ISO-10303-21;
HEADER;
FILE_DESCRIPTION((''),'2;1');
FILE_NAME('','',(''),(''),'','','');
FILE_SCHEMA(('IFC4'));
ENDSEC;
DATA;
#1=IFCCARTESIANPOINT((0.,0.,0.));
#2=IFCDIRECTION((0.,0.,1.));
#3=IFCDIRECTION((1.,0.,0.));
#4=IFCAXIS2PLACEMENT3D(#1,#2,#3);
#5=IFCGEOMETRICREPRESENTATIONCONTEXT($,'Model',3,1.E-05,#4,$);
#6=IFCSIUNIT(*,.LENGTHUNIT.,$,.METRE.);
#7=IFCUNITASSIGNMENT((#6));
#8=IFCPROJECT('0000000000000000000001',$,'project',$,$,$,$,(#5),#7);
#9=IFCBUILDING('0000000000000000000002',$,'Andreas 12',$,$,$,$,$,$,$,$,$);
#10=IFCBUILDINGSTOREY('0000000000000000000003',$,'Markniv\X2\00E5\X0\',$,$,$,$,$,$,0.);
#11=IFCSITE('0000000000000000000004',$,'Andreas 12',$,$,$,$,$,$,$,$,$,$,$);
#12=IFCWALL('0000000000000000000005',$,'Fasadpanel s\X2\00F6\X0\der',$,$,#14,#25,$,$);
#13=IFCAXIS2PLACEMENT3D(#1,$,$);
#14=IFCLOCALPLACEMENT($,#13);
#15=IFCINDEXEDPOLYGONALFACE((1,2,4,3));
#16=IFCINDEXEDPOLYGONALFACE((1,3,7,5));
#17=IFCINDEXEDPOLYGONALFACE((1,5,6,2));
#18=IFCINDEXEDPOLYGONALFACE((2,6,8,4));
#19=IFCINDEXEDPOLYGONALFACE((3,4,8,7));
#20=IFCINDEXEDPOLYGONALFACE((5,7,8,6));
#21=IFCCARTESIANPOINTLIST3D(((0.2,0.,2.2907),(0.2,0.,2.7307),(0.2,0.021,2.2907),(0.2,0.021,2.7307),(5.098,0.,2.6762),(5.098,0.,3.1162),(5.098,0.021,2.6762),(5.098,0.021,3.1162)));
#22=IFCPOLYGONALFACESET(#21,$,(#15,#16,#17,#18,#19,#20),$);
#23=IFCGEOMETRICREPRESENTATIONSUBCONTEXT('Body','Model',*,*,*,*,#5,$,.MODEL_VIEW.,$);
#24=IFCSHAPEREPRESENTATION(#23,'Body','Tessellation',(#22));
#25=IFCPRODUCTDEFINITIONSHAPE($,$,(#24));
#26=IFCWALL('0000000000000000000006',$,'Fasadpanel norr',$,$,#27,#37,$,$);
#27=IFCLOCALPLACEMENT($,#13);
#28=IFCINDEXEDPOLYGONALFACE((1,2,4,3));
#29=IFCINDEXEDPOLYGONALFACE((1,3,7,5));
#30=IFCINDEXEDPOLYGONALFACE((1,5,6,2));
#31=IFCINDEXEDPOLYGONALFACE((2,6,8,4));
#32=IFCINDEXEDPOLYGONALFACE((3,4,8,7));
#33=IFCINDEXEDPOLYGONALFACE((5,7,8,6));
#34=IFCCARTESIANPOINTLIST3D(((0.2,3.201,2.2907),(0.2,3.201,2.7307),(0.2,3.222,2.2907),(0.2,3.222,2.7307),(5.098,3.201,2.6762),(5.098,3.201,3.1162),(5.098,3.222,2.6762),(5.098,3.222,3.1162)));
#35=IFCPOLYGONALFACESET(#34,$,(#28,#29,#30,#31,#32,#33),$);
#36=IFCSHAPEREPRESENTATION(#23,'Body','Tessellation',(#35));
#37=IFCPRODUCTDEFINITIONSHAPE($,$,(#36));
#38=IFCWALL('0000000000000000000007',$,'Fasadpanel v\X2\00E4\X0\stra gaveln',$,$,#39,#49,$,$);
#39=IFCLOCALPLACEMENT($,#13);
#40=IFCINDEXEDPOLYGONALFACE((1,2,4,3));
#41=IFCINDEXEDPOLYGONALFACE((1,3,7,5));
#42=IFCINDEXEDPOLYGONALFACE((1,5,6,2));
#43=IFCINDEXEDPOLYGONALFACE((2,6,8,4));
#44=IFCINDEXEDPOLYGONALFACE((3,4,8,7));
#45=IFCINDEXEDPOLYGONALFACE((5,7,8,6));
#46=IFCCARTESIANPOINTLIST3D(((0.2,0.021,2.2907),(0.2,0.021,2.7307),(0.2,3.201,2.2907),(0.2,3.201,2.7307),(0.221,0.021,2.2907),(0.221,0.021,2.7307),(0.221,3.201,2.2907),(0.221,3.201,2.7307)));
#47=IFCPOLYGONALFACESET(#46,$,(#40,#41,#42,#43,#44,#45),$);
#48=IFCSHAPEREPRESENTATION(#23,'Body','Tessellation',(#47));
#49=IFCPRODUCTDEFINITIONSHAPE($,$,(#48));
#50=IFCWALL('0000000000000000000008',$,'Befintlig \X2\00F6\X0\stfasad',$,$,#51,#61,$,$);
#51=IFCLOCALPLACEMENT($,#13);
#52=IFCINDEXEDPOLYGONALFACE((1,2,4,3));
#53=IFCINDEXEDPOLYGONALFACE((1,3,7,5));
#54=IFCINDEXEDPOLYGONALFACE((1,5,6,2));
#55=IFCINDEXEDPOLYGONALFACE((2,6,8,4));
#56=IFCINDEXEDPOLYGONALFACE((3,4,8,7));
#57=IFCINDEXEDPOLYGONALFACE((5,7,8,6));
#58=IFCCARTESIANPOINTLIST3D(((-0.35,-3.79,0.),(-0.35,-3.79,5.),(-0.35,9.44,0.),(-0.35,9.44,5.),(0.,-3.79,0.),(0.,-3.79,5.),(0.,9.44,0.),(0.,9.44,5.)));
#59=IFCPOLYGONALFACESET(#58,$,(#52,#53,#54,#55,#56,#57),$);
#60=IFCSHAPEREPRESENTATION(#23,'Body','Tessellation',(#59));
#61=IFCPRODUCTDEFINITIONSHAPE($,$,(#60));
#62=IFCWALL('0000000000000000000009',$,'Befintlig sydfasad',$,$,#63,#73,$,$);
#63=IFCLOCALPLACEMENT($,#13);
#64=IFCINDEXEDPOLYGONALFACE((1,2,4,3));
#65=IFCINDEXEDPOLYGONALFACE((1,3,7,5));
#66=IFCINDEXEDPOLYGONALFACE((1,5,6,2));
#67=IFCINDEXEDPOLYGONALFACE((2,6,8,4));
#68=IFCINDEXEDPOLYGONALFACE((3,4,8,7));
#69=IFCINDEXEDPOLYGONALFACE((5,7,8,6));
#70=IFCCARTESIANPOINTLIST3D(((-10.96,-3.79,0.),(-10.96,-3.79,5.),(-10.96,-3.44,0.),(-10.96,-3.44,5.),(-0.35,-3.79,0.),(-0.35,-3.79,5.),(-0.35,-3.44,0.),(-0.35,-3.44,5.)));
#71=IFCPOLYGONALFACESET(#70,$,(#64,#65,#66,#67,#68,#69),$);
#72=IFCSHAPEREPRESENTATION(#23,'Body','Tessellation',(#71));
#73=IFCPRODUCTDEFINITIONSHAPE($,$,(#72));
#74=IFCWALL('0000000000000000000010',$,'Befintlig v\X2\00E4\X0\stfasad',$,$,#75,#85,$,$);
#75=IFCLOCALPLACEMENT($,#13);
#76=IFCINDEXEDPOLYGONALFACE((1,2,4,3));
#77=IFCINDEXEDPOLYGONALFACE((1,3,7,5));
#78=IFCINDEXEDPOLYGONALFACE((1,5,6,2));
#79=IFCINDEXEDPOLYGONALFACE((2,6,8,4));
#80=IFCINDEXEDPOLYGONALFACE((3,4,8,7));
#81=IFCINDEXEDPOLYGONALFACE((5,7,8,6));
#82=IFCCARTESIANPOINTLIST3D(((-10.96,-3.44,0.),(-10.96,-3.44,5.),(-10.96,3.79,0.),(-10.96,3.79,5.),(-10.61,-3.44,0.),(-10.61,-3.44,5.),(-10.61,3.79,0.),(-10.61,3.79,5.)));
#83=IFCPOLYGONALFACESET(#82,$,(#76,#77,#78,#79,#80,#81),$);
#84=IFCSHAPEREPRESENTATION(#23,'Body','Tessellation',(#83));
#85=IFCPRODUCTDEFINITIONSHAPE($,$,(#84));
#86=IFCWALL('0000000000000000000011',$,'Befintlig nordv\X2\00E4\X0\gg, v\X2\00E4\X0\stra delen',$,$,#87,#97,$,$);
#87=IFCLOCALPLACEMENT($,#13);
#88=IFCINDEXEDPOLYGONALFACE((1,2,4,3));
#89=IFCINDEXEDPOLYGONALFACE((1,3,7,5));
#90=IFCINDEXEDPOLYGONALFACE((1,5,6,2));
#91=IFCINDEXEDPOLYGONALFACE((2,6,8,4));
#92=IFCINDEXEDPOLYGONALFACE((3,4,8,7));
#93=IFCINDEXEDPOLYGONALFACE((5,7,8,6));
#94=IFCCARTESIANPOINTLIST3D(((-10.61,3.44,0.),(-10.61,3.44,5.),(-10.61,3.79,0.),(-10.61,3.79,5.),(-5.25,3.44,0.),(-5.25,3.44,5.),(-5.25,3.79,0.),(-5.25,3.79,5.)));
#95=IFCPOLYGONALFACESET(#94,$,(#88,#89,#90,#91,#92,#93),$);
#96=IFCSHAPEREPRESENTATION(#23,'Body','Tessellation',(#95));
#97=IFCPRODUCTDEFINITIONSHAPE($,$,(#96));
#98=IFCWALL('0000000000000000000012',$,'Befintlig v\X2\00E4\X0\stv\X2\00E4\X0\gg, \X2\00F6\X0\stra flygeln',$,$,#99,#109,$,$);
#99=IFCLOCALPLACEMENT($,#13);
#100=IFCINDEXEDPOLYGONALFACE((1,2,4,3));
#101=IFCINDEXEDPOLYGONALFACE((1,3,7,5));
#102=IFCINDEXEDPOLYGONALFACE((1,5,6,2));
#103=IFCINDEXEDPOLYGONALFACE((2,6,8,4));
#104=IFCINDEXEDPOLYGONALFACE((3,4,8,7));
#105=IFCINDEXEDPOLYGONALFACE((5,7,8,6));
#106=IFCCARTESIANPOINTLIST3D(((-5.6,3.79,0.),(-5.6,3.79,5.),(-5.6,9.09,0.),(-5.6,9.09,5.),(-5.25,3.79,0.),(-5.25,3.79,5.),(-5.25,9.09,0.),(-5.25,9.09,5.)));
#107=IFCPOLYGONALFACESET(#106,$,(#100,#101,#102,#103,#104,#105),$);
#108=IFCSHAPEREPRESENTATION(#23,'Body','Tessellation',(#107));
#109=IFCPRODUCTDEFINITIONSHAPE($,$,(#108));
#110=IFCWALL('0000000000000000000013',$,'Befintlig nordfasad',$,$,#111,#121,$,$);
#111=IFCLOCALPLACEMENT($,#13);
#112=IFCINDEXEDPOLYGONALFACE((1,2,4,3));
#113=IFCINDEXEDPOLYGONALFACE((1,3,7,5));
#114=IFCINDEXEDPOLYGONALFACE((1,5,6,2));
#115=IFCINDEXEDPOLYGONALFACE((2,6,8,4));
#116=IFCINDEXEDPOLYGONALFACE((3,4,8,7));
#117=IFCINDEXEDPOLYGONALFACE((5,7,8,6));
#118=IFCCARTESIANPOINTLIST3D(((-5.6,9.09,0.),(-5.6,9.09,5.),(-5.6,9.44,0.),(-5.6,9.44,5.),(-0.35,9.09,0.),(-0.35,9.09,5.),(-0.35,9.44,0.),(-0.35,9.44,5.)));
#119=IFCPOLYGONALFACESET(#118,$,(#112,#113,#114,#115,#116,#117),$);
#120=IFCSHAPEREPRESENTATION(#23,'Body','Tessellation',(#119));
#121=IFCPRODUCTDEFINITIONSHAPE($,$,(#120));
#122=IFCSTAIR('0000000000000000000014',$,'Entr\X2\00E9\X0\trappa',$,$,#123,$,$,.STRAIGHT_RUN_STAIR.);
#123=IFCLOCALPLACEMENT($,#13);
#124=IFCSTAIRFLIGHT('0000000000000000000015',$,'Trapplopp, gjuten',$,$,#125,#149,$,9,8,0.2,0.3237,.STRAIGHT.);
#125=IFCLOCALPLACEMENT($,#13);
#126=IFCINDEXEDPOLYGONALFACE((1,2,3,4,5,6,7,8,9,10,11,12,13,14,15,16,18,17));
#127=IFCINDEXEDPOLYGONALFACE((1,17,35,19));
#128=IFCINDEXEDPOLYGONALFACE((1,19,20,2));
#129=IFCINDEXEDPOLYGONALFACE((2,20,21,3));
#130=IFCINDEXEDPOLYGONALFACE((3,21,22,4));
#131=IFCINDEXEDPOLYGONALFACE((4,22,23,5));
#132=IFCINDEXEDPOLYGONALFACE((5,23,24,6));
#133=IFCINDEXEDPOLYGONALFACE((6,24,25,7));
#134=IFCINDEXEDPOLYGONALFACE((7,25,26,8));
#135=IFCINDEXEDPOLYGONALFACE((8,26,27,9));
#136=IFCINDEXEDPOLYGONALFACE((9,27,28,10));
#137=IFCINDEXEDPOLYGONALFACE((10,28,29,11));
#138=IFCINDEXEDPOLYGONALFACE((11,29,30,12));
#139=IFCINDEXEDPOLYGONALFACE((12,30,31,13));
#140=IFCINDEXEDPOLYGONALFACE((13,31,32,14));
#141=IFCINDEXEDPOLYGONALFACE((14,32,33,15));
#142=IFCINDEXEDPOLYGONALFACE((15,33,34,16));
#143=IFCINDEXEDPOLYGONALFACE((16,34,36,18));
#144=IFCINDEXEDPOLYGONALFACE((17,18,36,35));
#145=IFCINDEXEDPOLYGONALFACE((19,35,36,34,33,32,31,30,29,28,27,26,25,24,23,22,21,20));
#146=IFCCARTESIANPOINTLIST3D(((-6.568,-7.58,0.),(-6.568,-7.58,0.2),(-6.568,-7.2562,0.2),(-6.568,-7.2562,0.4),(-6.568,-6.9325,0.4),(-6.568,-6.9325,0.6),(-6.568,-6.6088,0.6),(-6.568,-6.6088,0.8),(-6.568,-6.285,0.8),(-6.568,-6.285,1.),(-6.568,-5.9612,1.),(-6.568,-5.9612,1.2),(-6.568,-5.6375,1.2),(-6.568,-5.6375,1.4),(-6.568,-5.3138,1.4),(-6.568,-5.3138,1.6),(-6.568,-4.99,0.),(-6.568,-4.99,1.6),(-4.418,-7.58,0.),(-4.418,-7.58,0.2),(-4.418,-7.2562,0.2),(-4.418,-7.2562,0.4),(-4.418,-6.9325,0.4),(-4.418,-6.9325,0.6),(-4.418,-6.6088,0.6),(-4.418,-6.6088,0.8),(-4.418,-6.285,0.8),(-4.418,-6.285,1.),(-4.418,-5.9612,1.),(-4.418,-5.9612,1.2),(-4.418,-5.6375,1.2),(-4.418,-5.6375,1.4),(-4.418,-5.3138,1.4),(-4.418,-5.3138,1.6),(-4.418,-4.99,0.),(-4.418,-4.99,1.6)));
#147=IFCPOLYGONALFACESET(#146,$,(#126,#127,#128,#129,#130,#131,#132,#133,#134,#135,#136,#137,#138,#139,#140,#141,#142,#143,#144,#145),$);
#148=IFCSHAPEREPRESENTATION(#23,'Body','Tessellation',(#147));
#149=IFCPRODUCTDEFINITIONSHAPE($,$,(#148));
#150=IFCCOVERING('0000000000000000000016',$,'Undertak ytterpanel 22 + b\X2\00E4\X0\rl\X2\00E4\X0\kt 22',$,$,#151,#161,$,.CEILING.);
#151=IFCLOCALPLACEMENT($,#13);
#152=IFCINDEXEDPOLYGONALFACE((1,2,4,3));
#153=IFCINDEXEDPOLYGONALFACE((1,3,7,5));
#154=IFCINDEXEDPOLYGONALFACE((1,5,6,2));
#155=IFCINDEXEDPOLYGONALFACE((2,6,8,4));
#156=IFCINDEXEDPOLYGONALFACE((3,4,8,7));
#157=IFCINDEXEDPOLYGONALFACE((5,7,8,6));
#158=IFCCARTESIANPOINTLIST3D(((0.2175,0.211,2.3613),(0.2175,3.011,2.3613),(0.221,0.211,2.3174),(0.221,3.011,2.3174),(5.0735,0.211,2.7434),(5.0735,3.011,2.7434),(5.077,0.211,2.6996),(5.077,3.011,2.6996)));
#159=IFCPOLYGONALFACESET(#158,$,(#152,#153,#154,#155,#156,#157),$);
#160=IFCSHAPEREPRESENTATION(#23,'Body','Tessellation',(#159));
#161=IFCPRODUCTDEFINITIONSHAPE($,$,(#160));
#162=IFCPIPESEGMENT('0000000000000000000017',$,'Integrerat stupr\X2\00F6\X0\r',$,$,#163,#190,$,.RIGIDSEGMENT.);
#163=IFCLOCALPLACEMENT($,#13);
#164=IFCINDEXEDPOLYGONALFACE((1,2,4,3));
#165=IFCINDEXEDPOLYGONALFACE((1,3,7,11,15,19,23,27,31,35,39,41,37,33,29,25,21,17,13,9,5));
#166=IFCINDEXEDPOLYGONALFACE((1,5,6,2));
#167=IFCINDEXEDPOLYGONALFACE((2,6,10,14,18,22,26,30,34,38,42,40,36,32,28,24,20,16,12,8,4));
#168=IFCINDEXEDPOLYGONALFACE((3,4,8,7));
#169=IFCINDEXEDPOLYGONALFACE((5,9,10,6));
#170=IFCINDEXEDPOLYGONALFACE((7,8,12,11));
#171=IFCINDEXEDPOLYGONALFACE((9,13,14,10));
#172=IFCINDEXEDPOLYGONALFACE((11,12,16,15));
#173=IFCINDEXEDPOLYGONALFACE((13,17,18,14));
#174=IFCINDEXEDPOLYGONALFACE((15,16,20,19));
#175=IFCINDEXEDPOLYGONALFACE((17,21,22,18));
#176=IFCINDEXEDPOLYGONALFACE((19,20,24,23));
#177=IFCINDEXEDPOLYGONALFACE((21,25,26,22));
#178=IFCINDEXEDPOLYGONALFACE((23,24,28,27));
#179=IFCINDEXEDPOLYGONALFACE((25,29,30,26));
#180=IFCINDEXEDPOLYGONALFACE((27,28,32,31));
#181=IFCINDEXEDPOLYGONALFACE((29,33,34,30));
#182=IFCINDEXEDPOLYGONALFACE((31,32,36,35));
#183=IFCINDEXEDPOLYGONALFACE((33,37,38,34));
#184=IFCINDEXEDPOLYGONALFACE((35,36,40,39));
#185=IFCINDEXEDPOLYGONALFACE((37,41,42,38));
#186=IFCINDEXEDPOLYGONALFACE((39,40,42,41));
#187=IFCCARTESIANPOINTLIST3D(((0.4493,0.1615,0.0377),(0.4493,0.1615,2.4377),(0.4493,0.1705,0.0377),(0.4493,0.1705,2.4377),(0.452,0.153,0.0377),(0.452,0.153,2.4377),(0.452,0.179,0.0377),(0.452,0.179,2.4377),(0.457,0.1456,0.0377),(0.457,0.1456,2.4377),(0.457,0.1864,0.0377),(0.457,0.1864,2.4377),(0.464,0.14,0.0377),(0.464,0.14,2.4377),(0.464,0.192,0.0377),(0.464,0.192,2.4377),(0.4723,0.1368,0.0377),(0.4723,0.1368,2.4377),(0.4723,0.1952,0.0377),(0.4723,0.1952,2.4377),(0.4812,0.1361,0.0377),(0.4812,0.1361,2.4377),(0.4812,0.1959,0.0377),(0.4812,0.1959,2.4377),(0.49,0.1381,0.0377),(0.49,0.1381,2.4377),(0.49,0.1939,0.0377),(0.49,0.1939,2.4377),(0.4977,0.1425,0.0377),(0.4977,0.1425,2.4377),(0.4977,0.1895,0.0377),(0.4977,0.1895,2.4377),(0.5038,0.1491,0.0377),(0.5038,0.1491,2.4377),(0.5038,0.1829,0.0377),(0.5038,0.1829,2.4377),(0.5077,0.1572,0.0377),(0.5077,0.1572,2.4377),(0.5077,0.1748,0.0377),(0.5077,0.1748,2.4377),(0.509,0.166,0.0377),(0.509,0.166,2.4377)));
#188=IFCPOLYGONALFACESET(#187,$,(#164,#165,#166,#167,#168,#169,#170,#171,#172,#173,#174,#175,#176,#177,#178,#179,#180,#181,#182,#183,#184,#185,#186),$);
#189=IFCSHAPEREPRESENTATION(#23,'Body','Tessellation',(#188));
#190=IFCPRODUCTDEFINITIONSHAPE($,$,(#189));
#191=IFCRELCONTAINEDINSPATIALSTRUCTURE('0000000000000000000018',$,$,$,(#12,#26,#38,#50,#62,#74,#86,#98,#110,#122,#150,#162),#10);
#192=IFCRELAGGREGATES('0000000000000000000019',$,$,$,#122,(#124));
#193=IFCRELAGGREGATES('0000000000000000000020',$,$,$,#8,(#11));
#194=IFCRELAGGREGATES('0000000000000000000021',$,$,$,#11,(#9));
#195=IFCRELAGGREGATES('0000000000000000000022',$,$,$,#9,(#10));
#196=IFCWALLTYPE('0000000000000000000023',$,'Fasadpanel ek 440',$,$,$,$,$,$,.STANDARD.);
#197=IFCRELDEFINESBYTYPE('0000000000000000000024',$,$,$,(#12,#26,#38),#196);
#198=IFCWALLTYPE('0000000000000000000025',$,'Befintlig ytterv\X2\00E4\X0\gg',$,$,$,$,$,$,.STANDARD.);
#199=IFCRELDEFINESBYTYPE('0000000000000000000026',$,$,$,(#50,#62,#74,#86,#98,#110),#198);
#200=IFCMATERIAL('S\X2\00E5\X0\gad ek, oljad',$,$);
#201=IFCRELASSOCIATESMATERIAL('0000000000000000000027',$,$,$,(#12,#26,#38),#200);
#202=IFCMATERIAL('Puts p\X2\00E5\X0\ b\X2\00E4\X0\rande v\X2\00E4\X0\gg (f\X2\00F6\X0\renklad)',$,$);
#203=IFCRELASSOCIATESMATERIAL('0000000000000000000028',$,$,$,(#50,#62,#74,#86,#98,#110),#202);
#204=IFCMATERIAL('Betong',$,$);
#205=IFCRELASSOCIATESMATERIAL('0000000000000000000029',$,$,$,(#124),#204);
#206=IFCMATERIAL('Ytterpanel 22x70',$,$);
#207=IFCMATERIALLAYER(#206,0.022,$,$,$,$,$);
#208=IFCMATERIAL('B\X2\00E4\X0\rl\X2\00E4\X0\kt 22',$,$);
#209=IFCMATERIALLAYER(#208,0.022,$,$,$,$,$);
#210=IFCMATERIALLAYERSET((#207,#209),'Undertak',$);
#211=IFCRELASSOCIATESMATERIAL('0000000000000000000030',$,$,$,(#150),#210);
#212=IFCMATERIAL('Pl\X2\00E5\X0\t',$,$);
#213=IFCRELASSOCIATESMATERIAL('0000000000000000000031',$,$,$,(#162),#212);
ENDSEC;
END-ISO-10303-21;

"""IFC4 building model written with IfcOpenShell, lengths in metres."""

from ifc_helpers import new_model, si_unit, frame, frame_2d, origin, origin_with_axes, origin_2d, place, context, subcontext, project, spatial, polyline, rectangle, circle, outline, extrude, clip, halfspace, material, layer, layer_set, layer_usage, type_object, element, aggregate, save


model = new_model("IFC4")

# Units and contexts
model_context = context("Model", 3, precision=1e-05, world=origin_with_axes())
body_context = subcontext(model_context, "Body", "Model", "MODEL_VIEW")
ifc_project = project(units=[si_unit("LENGTHUNIT", "METRE")], contexts=[model_context])

# Site, building, storey
site = spatial("IfcSite", under=ifc_project, Name="Andreas 12")
building = spatial("IfcBuilding", under=site, Name="Andreas 12")
storey = spatial("IfcBuildingStorey", under=building, Name="Marknivå", Elevation=0.0)

# Shared definitions
ifc_material_1 = material(Name="Betong")

# Walls
ifc_material_2 = material(Name="Sågad ek, oljad")
wall_type_1 = type_object("IfcWallType", Name="Fasadpanel ek 440", PredefinedType="STANDARD")
for number, where, z_axis, x_axis, name in (
    (1, (0.2, 0.0, 2.2907), (0.0, 0.0, 1.0), (1.0, 0.0, 0.0), "Fasadpanel söder"),
    (2, (0.2, 3.201, 2.2907), (0.0, 0.0, 1.0), (1.0, 0.0, 0.0), "Fasadpanel norr"),
):
    element("IfcWall", number, at=place(None, frame(where, z_axis=z_axis, x_axis=x_axis)), inside=storey, type_object=wall_type_1, material=ifc_material_2, Name=name, context=body_context, shape_type="Clipping", body=[
        clip(clip(extrude(rectangle(XDim=4.898, YDim=0.021, at=frame_2d((2.449, 0.0105))), origin(), (0.0, 0.0, 1.0), 0.8755), halfspace(frame((0.0, 0.0, 0.0), z_axis=(-0.078459, 0.0, 0.996917), x_axis=(0.996917, 0.0, 0.078459)), True)), halfspace(frame((0.0, 0.0, 0.44), z_axis=(-0.078459, 0.0, 0.996917), x_axis=(0.996917, 0.0, 0.078459)), False)),
    ])
wall_1_placement = place(None, frame((0.2, 0.021, 2.2907), z_axis=(0.0, 0.0, 1.0), x_axis=(1.0, 0.0, 0.0)))
element("IfcWall", 3, at=wall_1_placement, inside=storey, type_object=wall_type_1, material=ifc_material_2, Name="Fasadpanel västra gaveln", context=body_context, shape_type="SweptSolid", body=[
    extrude(rectangle(XDim=0.021, YDim=3.18, at=frame_2d((0.0105, 1.59))), origin(), (0.0, 0.0, 1.0), 0.44),
])
ifc_material_3 = material(Name="Puts på bärande vägg (förenklad)")
wall_type_2 = type_object("IfcWallType", Name="Befintlig yttervägg", PredefinedType="STANDARD")
wall_2_placement = place(None, frame((-0.35, -3.79, 0.0), z_axis=(0.0, 0.0, 1.0), x_axis=(1.0, 0.0, 0.0)))
element("IfcWall", 4, at=wall_2_placement, inside=storey, type_object=wall_type_2, material=ifc_material_3, Name="Befintlig östfasad", context=body_context, shape_type="SweptSolid", body=[
    extrude(rectangle(XDim=0.35, YDim=13.23, at=frame_2d((0.175, 6.615))), origin(), (0.0, 0.0, 1.0), 5.0),
])
wall_3_placement = place(None, frame((-10.96, -3.79, 0.0), z_axis=(0.0, 0.0, 1.0), x_axis=(1.0, 0.0, 0.0)))
element("IfcWall", 5, at=wall_3_placement, inside=storey, type_object=wall_type_2, material=ifc_material_3, Name="Befintlig sydfasad", context=body_context, shape_type="SweptSolid", body=[
    extrude(rectangle(XDim=10.61, YDim=0.35, at=frame_2d((5.305, 0.175))), origin(), (0.0, 0.0, 1.0), 5.0),
])
wall_4_placement = place(None, frame((-10.96, -3.44, 0.0), z_axis=(0.0, 0.0, 1.0), x_axis=(1.0, 0.0, 0.0)))
element("IfcWall", 6, at=wall_4_placement, inside=storey, type_object=wall_type_2, material=ifc_material_3, Name="Befintlig västfasad", context=body_context, shape_type="SweptSolid", body=[
    extrude(rectangle(XDim=0.35, YDim=7.23, at=frame_2d((0.175, 3.615))), origin(), (0.0, 0.0, 1.0), 5.0),
])
wall_5_placement = place(None, frame((-10.61, 3.44, 0.0), z_axis=(0.0, 0.0, 1.0), x_axis=(1.0, 0.0, 0.0)))
element("IfcWall", 7, at=wall_5_placement, inside=storey, type_object=wall_type_2, material=ifc_material_3, Name="Befintlig nordvägg, västra delen", context=body_context, shape_type="SweptSolid", body=[
    extrude(rectangle(XDim=5.36, YDim=0.35, at=frame_2d((2.68, 0.175))), origin(), (0.0, 0.0, 1.0), 5.0),
])
wall_6_placement = place(None, frame((-5.6, 3.79, 0.0), z_axis=(0.0, 0.0, 1.0), x_axis=(1.0, 0.0, 0.0)))
element("IfcWall", 8, at=wall_6_placement, inside=storey, type_object=wall_type_2, material=ifc_material_3, Name="Befintlig västvägg, östra flygeln", context=body_context, shape_type="SweptSolid", body=[
    extrude(rectangle(XDim=0.35, YDim=5.3, at=frame_2d((0.175, 2.65))), origin(), (0.0, 0.0, 1.0), 5.0),
])
wall_7_placement = place(None, frame((-5.6, 9.09, 0.0), z_axis=(0.0, 0.0, 1.0), x_axis=(1.0, 0.0, 0.0)))
element("IfcWall", 9, at=wall_7_placement, inside=storey, type_object=wall_type_2, material=ifc_material_3, Name="Befintlig nordfasad", context=body_context, shape_type="SweptSolid", body=[
    extrude(rectangle(XDim=5.25, YDim=0.35, at=frame_2d((2.625, 0.175))), origin(), (0.0, 0.0, 1.0), 5.0),
])

# Stair, stair flight
stair = element("IfcStair", 10, inside=storey, Name="Entrétrappa", PredefinedType="STRAIGHT_RUN_STAIR")
stair_flight_placement = place(None, frame((-4.418, -4.99, 0.0), z_axis=(-1.0, 0.0, 0.0), x_axis=(0.0, -1.0, 0.0)))
stair_flight = element("IfcStairFlight", 11, at=stair_flight_placement, material=ifc_material_1, Name="Trapplopp, gjuten", NumberOfRisers=9, NumberOfTreads=8, PredefinedType="STRAIGHT", RiserHeight=0.2, TreadLength=0.3237, context=body_context, shape_type="SweptSolid", body=[
    extrude(outline(polyline([(0.0, 0.0), (0.0, 1.6), (0.3237, 1.6), (0.3237, 1.4), (0.6475, 1.4), (0.6475, 1.2), (0.9712, 1.2), (0.9712, 1.0), (1.295, 1.0), (1.295, 0.8), (1.6187, 0.8), (1.6187, 0.6), (1.9425, 0.6), (1.9425, 0.4), (2.2662, 0.4), (2.2662, 0.2), (2.59, 0.2), (2.59, 0.0), (0.0, 0.0)])), origin(), (0.0, 0.0, 1.0), 2.15),
])
aggregate(stair, [stair_flight])

# Covering
ifc_material_4 = material(Name="Ytterpanel 22x70")
ifc_layer_1 = layer(ifc_material_4, 0.022)
ifc_material_5 = material(Name="Bärläkt 22")
ifc_layer_2 = layer(ifc_material_5, 0.022)
ifc_layer_set_1 = layer_set([ifc_layer_1, ifc_layer_2], Name="Undertak")
ifc_layer_usage_1 = layer_usage(ifc_layer_set_1, "AXIS3", "POSITIVE", 0.0)
covering_placement = place(None, frame((0.221, 0.211, 2.3174), z_axis=(-0.078459, 0.0, 0.996917), x_axis=(0.996917, 0.0, 0.078459)))
element("IfcCovering", 12, at=covering_placement, inside=storey, material=ifc_layer_usage_1, Name="Undertak ytterpanel 22 + bärläkt 22", PredefinedType="CEILING", context=body_context, shape_type="SweptSolid", body=[
    extrude(rectangle(XDim=4.871, YDim=2.8, at=frame_2d((2.4355, 1.4))), origin(), (0.0, 0.0, 1.0), 0.044),
])

# Pipe segment
ifc_material_6 = material(Name="Plåt")
pipe_segment_placement = place(None, frame((0.479, 0.166, 0.0377), z_axis=(0.0, 0.0, 1.0), x_axis=(1.0, 0.0, 0.0)))
element("IfcPipeSegment", 13, at=pipe_segment_placement, inside=storey, material=ifc_material_6, Name="Integrerat stuprör", PredefinedType="RIGIDSEGMENT", context=body_context, shape_type="SweptSolid", body=[
    extrude(circle(Radius=0.03, at=origin_2d()), origin(), (0.0, 0.0, 1.0), 2.4),
])

save(model, "model.ifc")
